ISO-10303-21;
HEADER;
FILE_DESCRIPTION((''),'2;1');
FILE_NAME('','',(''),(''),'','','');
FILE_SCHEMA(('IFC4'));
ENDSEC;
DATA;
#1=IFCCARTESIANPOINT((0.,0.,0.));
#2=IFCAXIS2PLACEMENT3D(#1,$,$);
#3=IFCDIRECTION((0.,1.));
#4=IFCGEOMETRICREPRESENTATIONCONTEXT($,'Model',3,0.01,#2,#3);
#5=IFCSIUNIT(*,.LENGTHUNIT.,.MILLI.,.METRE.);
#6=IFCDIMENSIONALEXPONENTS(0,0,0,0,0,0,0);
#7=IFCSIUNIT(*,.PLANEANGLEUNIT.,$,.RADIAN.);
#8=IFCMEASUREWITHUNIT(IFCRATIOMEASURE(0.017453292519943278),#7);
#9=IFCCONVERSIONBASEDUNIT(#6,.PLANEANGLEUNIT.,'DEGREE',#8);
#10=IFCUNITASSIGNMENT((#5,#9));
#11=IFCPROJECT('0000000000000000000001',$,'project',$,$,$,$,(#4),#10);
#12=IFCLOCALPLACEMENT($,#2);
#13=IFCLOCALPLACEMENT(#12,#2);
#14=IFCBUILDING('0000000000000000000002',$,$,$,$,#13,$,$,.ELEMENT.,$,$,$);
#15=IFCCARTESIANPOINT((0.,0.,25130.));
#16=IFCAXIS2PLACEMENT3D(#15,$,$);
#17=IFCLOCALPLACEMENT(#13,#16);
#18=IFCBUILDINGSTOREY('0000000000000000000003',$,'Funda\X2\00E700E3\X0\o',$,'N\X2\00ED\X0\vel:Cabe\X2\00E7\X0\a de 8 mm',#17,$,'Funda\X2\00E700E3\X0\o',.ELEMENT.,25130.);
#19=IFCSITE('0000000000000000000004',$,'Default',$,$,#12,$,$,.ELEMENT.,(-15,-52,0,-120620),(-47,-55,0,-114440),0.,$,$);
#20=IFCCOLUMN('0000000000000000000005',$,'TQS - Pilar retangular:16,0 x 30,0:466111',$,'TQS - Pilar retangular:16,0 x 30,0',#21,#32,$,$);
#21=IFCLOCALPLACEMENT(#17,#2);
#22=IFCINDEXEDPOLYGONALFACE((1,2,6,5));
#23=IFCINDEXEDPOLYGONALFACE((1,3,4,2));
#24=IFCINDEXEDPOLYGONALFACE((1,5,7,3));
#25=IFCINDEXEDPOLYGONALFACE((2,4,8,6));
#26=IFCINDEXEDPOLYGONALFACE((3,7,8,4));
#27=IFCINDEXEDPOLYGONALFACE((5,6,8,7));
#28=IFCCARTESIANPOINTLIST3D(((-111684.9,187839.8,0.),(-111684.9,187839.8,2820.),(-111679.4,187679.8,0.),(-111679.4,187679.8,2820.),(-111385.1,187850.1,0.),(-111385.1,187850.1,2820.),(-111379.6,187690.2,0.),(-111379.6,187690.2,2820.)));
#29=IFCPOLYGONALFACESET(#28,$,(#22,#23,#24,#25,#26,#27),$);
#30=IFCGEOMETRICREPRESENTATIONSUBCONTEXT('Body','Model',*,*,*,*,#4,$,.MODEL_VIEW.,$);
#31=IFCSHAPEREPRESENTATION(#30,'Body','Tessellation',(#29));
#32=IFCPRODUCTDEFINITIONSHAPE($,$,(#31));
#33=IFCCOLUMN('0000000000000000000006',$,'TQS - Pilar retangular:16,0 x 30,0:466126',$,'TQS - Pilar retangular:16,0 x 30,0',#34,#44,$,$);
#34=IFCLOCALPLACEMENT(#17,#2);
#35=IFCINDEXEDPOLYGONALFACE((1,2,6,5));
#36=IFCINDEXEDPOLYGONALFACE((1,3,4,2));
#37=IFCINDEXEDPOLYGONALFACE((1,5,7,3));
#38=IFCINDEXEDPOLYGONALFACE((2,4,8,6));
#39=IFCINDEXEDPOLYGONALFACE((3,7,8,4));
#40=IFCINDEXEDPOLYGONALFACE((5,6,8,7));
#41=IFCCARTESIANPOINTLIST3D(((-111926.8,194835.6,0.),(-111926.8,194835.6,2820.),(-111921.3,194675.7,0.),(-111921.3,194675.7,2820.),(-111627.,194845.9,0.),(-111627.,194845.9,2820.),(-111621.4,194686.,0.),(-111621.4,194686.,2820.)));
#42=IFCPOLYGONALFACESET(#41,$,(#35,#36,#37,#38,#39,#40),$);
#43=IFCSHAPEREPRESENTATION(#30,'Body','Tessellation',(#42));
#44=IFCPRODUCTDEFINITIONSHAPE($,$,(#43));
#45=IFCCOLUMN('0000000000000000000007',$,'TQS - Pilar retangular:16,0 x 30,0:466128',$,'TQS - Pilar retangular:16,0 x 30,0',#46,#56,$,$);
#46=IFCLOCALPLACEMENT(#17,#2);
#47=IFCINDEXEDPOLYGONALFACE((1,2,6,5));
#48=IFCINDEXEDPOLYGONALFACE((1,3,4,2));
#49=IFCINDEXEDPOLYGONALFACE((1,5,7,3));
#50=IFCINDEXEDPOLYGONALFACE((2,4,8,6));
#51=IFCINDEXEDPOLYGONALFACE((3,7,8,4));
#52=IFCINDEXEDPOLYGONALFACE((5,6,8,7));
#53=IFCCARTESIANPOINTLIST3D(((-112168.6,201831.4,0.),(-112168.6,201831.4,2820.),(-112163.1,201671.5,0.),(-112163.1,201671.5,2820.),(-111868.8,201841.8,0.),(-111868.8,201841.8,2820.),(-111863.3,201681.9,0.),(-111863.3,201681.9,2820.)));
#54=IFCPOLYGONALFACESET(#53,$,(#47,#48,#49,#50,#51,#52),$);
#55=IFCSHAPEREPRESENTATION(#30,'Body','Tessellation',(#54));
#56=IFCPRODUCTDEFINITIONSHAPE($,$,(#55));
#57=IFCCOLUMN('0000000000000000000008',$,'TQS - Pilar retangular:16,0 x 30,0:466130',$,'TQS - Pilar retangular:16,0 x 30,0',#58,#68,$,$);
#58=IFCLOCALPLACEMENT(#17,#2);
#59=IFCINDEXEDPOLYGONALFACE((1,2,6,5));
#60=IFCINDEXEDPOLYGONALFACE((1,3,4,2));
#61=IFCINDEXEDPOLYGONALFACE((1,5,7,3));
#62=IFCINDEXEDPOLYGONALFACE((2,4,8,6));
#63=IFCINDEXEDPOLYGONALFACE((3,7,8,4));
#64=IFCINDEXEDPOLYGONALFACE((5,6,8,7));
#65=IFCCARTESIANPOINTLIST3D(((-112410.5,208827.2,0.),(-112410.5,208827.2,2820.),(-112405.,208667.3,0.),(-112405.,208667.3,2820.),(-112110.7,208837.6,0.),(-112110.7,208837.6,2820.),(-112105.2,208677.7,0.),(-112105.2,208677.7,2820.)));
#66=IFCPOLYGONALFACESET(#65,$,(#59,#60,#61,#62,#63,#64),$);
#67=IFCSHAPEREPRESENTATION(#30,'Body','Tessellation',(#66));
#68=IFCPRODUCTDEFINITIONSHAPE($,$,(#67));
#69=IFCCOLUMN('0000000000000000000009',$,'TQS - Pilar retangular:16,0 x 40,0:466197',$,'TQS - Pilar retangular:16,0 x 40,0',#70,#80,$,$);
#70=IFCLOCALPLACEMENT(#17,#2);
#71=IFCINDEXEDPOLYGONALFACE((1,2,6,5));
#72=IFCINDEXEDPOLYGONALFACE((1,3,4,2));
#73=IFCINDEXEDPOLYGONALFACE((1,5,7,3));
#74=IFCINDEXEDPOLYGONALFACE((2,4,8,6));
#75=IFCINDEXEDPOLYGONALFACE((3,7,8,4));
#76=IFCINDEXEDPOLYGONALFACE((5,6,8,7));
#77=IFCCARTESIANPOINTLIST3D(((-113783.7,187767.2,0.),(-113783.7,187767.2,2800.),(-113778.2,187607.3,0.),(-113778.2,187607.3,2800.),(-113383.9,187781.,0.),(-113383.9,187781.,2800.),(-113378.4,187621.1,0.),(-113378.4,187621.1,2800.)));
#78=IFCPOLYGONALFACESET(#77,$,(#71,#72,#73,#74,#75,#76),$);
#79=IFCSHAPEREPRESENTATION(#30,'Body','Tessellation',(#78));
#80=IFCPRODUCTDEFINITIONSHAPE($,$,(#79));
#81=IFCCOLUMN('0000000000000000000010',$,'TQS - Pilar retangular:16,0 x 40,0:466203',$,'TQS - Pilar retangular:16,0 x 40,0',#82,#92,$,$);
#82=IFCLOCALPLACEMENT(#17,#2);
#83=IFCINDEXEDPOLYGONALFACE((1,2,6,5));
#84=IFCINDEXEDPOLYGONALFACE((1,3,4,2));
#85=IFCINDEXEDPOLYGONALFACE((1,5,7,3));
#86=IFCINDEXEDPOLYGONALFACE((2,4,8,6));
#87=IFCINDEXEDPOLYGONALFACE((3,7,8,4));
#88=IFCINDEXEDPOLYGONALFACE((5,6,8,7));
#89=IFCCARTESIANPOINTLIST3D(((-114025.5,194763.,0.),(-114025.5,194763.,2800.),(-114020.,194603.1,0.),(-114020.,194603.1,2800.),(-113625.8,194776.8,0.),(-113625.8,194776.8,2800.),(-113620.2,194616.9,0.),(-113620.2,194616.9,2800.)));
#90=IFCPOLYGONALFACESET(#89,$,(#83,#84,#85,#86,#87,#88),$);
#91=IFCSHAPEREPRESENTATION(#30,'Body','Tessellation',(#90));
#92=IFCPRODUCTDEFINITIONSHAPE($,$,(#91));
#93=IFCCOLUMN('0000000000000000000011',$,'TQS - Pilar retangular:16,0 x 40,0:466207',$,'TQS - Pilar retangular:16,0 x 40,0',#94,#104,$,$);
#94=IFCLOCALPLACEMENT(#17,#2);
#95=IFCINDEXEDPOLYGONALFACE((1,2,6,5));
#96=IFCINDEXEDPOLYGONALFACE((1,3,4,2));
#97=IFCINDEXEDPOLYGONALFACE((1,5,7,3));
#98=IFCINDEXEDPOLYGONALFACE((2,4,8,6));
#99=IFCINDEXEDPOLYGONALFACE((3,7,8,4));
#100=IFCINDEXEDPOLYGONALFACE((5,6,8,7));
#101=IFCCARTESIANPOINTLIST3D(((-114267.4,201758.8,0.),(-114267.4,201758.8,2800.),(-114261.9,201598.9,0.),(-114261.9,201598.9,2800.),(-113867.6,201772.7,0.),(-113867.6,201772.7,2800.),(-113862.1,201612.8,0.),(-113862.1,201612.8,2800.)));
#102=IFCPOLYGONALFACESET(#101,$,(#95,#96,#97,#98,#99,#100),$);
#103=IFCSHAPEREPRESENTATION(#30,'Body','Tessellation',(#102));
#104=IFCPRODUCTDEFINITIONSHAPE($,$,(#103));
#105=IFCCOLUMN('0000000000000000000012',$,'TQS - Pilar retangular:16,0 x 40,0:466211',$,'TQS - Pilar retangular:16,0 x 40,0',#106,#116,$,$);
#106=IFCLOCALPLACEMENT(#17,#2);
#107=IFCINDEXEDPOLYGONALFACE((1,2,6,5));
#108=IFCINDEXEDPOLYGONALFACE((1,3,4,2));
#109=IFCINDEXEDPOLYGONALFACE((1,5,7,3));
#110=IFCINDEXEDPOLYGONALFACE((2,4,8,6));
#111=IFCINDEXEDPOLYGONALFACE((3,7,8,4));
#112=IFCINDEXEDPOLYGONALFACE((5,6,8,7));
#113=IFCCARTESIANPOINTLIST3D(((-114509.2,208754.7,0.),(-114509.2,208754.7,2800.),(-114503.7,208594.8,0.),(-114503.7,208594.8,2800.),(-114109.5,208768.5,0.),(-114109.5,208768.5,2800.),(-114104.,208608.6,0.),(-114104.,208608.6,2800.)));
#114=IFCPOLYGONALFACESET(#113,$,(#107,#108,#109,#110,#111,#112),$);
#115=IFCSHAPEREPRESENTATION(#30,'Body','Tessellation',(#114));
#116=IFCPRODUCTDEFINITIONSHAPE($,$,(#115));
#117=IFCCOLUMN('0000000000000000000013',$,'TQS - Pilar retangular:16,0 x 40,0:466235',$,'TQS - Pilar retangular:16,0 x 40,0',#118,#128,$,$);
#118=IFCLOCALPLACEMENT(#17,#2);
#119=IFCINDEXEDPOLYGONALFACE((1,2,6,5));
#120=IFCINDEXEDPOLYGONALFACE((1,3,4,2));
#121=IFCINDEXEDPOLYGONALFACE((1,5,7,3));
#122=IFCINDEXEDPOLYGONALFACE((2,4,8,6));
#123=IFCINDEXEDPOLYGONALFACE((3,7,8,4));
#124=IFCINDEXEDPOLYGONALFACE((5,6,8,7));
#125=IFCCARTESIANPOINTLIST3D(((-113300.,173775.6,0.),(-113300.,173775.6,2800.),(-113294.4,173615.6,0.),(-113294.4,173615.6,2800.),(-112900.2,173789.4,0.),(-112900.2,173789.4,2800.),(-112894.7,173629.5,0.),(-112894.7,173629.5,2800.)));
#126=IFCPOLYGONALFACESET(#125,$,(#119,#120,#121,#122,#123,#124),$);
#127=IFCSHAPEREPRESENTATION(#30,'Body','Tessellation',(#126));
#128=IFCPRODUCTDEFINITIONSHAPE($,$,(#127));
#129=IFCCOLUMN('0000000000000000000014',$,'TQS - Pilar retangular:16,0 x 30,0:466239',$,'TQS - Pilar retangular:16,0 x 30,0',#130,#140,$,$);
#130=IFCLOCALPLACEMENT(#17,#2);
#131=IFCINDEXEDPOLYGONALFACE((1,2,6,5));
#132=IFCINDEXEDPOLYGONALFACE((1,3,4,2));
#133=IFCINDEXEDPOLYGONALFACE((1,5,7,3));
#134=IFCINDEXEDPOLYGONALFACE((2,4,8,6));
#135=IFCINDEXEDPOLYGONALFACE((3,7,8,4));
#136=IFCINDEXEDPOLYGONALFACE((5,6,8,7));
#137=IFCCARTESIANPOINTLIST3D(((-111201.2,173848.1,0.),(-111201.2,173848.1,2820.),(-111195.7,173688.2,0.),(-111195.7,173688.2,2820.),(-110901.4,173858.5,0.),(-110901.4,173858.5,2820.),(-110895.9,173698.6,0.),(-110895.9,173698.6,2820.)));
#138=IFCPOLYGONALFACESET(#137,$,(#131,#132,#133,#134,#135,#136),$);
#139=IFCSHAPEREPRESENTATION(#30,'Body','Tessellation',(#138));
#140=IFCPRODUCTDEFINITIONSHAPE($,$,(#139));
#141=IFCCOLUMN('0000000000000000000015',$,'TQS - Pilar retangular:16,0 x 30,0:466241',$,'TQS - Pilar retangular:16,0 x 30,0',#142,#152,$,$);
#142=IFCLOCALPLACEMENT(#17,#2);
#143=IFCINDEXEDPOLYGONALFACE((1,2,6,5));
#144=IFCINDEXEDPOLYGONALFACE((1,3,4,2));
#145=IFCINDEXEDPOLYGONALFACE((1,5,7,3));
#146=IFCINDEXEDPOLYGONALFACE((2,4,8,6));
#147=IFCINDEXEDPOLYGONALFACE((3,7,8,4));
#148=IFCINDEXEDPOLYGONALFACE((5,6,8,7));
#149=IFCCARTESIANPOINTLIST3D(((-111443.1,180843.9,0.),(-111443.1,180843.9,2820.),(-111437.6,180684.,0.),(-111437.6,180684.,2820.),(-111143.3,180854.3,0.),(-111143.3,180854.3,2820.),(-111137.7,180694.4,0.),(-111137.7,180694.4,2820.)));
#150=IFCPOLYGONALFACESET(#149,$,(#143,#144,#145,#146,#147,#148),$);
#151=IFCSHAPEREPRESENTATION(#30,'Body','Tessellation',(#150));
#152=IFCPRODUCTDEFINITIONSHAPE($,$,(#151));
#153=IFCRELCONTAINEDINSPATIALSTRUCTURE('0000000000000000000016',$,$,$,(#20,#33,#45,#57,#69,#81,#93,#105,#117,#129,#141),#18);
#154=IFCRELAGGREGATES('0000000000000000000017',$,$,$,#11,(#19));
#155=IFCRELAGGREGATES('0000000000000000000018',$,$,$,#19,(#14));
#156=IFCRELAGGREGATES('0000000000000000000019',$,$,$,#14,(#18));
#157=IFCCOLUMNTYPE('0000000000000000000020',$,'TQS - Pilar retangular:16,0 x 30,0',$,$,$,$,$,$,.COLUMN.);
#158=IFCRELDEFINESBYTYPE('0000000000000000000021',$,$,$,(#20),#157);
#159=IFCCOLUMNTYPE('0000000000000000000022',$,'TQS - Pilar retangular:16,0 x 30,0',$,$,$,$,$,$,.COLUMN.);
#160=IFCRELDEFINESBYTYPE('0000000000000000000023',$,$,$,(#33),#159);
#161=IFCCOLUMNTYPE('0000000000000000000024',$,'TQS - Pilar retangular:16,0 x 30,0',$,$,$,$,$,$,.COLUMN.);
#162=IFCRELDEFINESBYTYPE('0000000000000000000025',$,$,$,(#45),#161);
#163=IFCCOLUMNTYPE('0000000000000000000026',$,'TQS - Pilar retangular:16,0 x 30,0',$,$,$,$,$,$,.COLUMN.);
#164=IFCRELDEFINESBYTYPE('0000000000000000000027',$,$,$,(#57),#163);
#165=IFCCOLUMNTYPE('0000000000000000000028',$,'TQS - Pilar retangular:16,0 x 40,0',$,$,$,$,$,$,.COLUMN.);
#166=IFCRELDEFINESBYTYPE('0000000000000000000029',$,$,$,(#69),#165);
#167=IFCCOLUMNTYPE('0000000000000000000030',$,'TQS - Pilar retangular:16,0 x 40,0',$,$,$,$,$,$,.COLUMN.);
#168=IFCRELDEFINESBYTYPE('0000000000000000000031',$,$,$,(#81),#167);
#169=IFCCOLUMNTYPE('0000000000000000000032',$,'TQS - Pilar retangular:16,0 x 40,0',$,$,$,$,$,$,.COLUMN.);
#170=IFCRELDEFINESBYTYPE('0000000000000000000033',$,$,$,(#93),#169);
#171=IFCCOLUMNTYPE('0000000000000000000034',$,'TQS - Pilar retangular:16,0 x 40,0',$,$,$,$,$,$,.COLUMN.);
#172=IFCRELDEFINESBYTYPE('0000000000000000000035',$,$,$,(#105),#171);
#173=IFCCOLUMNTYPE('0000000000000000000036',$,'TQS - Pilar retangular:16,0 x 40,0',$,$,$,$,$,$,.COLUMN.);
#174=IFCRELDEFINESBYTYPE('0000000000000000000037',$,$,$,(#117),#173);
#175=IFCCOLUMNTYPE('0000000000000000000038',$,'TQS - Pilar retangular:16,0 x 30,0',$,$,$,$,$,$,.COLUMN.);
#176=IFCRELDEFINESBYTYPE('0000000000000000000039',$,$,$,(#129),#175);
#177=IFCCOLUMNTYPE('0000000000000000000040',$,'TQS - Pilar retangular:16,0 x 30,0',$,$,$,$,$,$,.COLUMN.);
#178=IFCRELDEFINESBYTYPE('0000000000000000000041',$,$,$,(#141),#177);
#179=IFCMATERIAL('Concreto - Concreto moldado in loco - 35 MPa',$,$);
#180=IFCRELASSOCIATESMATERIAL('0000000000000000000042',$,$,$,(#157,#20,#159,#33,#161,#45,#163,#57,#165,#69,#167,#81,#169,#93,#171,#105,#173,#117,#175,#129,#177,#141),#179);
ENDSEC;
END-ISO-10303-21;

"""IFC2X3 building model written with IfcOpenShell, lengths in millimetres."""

from ifc_helpers import new_model, entity, si_unit, converted_unit, direction, frame, frame_2d, origin, origin_2d_with_axis, place, context, subcontext, project, spatial, rectangle, extrude, source, transform, mapped, material, type_object, type_shapes, element, save


model = new_model("IFC2X3")

# Units and contexts
model_context = context("Model", 3, precision=0.01, world=origin(), true_north=direction((0.0, 1.0)))
body_context = subcontext(model_context, "Body", "Model", "MODEL_VIEW")
ifc_project = project(units=[si_unit("LENGTHUNIT", "METRE", prefix="MILLI"), converted_unit("PLANEANGLEUNIT", "DEGREE", entity("IfcRatioMeasure", 0.017453292519943278), si_unit("PLANEANGLEUNIT", "RADIAN"), dimensions=[0, 0, 0, 0, 0, 0, 0])], contexts=[model_context])

# Site, building, storey
site_placement = place(None, origin())
site = spatial("IfcSite", under=ifc_project, at=site_placement, Name="Default", CompositionType="ELEMENT", RefLatitude=(-15, -52, 0, -120620), RefLongitude=(-47, -55, 0, -114440), RefElevation=0.0)
building_placement = place(site_placement, origin())
building = spatial("IfcBuilding", under=site, at=building_placement, CompositionType="ELEMENT")
storey_placement = place(building_placement, frame((0.0, 0.0, 25130.0)))
storey = spatial("IfcBuildingStorey", under=building, at=storey_placement, Name="Fundação", ObjectType="Nível:Cabeça de 8 mm", LongName="Fundação", CompositionType="ELEMENT", Elevation=25130.0)

# Columns
ifc_material_1 = material(Name="Concreto - Concreto moldado in loco - 35 MPa")
column_type_1 = type_object("IfcColumnType", Name="TQS - Pilar retangular:16,0 x 30,0", PredefinedType="COLUMN", material=ifc_material_1)
shared_shape_1 = source(origin(), body_context, "Body", "SweptSolid", [
    extrude(rectangle(XDim=300.0, YDim=160.0, at=origin_2d_with_axis()), frame((-111532.3, 187765.0, 25130.0), z_axis=(0.0, 0.0, 1.0), x_axis=(-0.999403, -0.034551, 0.0)), (0.0, 0.0, 1.0), 2820.0),
])
type_shapes(column_type_1, [shared_shape_1])
column_1_placement = place(storey_placement, frame((0.0, 0.0, -25130.0)))
element("IfcColumn", 1, at=column_1_placement, inside=storey, type_object=column_type_1, material=ifc_material_1, Name="TQS - Pilar retangular:16,0 x 30,0:466111", ObjectType="TQS - Pilar retangular:16,0 x 30,0", context=body_context, shape_type="MappedRepresentation", body=[
    mapped(shared_shape_1, transform((0.0, 0.0, 0.0), scale=1.0)),
])
column_type_2 = type_object("IfcColumnType", Name="TQS - Pilar retangular:16,0 x 30,0", PredefinedType="COLUMN", material=ifc_material_1)
shared_shape_2 = source(origin(), body_context, "Body", "SweptSolid", [
    extrude(rectangle(XDim=300.0, YDim=160.0, at=origin_2d_with_axis()), frame((-111774.1, 194760.8, 25130.0), z_axis=(0.0, 0.0, 1.0), x_axis=(-0.999403, -0.034551, 0.0)), (0.0, 0.0, 1.0), 2820.0),
])
type_shapes(column_type_2, [shared_shape_2])
column_2_placement = place(storey_placement, frame((0.0, 0.0, -25130.0)))
element("IfcColumn", 2, at=column_2_placement, inside=storey, type_object=column_type_2, material=ifc_material_1, Name="TQS - Pilar retangular:16,0 x 30,0:466126", ObjectType="TQS - Pilar retangular:16,0 x 30,0", context=body_context, shape_type="MappedRepresentation", body=[
    mapped(shared_shape_2, transform((0.0, 0.0, 0.0), scale=1.0)),
])
column_type_3 = type_object("IfcColumnType", Name="TQS - Pilar retangular:16,0 x 30,0", PredefinedType="COLUMN", material=ifc_material_1)
shared_shape_3 = source(origin(), body_context, "Body", "SweptSolid", [
    extrude(rectangle(XDim=300.0, YDim=160.0, at=origin_2d_with_axis()), frame((-112016.0, 201756.6, 25130.0), z_axis=(0.0, 0.0, 1.0), x_axis=(-0.999403, -0.034551, 0.0)), (0.0, 0.0, 1.0), 2820.0),
])
type_shapes(column_type_3, [shared_shape_3])
column_3_placement = place(storey_placement, frame((0.0, 0.0, -25130.0)))
element("IfcColumn", 3, at=column_3_placement, inside=storey, type_object=column_type_3, material=ifc_material_1, Name="TQS - Pilar retangular:16,0 x 30,0:466128", ObjectType="TQS - Pilar retangular:16,0 x 30,0", context=body_context, shape_type="MappedRepresentation", body=[
    mapped(shared_shape_3, transform((0.0, 0.0, 0.0), scale=1.0)),
])
column_type_4 = type_object("IfcColumnType", Name="TQS - Pilar retangular:16,0 x 30,0", PredefinedType="COLUMN", material=ifc_material_1)
shared_shape_4 = source(origin(), body_context, "Body", "SweptSolid", [
    extrude(rectangle(XDim=300.0, YDim=160.0, at=origin_2d_with_axis()), frame((-112257.8, 208752.4, 25130.0), z_axis=(0.0, 0.0, 1.0), x_axis=(-0.999403, -0.034551, 0.0)), (0.0, 0.0, 1.0), 2820.0),
])
type_shapes(column_type_4, [shared_shape_4])
column_4_placement = place(storey_placement, frame((0.0, 0.0, -25130.0)))
element("IfcColumn", 4, at=column_4_placement, inside=storey, type_object=column_type_4, material=ifc_material_1, Name="TQS - Pilar retangular:16,0 x 30,0:466130", ObjectType="TQS - Pilar retangular:16,0 x 30,0", context=body_context, shape_type="MappedRepresentation", body=[
    mapped(shared_shape_4, transform((0.0, 0.0, 0.0), scale=1.0)),
])
column_type_5 = type_object("IfcColumnType", Name="TQS - Pilar retangular:16,0 x 40,0", PredefinedType="COLUMN", material=ifc_material_1)
shared_shape_5 = source(origin(), body_context, "Body", "SweptSolid", [
    extrude(rectangle(XDim=400.0, YDim=160.0, at=origin_2d_with_axis()), frame((-113581.0, 187694.2, 25130.0), z_axis=(0.0, 0.0, 1.0), x_axis=(-0.999403, -0.034551, 0.0)), (0.0, 0.0, 1.0), 2800.0),
])
type_shapes(column_type_5, [shared_shape_5])
column_5_placement = place(storey_placement, frame((0.0, 0.0, -25130.0)))
element("IfcColumn", 5, at=column_5_placement, inside=storey, type_object=column_type_5, material=ifc_material_1, Name="TQS - Pilar retangular:16,0 x 40,0:466197", ObjectType="TQS - Pilar retangular:16,0 x 40,0", context=body_context, shape_type="MappedRepresentation", body=[
    mapped(shared_shape_5, transform((0.0, 0.0, 0.0), scale=1.0)),
])
column_type_6 = type_object("IfcColumnType", Name="TQS - Pilar retangular:16,0 x 40,0", PredefinedType="COLUMN", material=ifc_material_1)
shared_shape_6 = source(origin(), body_context, "Body", "SweptSolid", [
    extrude(rectangle(XDim=400.0, YDim=160.0, at=origin_2d_with_axis()), frame((-113822.9, 194690.0, 25130.0), z_axis=(0.0, 0.0, 1.0), x_axis=(-0.999403, -0.034551, 0.0)), (0.0, 0.0, 1.0), 2800.0),
])
type_shapes(column_type_6, [shared_shape_6])
column_6_placement = place(storey_placement, frame((0.0, 0.0, -25130.0)))
element("IfcColumn", 6, at=column_6_placement, inside=storey, type_object=column_type_6, material=ifc_material_1, Name="TQS - Pilar retangular:16,0 x 40,0:466203", ObjectType="TQS - Pilar retangular:16,0 x 40,0", context=body_context, shape_type="MappedRepresentation", body=[
    mapped(shared_shape_6, transform((0.0, 0.0, 0.0), scale=1.0)),
])
column_type_7 = type_object("IfcColumnType", Name="TQS - Pilar retangular:16,0 x 40,0", PredefinedType="COLUMN", material=ifc_material_1)
shared_shape_7 = source(origin(), body_context, "Body", "SweptSolid", [
    extrude(rectangle(XDim=400.0, YDim=160.0, at=origin_2d_with_axis()), frame((-114064.7, 201685.8, 25130.0), z_axis=(0.0, 0.0, 1.0), x_axis=(-0.999403, -0.034551, 0.0)), (0.0, 0.0, 1.0), 2800.0),
])
type_shapes(column_type_7, [shared_shape_7])
column_7_placement = place(storey_placement, frame((0.0, 0.0, -25130.0)))
element("IfcColumn", 7, at=column_7_placement, inside=storey, type_object=column_type_7, material=ifc_material_1, Name="TQS - Pilar retangular:16,0 x 40,0:466207", ObjectType="TQS - Pilar retangular:16,0 x 40,0", context=body_context, shape_type="MappedRepresentation", body=[
    mapped(shared_shape_7, transform((0.0, 0.0, 0.0), scale=1.0)),
])
column_type_8 = type_object("IfcColumnType", Name="TQS - Pilar retangular:16,0 x 40,0", PredefinedType="COLUMN", material=ifc_material_1)
shared_shape_8 = source(origin(), body_context, "Body", "SweptSolid", [
    extrude(rectangle(XDim=400.0, YDim=160.0, at=frame_2d((0.0, 0.0), x_axis=(1.0, 0.0))), frame((-114306.6, 208681.6, 25130.0), z_axis=(0.0, 0.0, 1.0), x_axis=(-0.999403, -0.034551, 0.0)), (0.0, 0.0, 1.0), 2800.0),
])
type_shapes(column_type_8, [shared_shape_8])
column_8_placement = place(storey_placement, frame((0.0, 0.0, -25130.0)))
element("IfcColumn", 8, at=column_8_placement, inside=storey, type_object=column_type_8, material=ifc_material_1, Name="TQS - Pilar retangular:16,0 x 40,0:466211", ObjectType="TQS - Pilar retangular:16,0 x 40,0", context=body_context, shape_type="MappedRepresentation", body=[
    mapped(shared_shape_8, transform((0.0, 0.0, 0.0), scale=1.0)),
])
column_type_9 = type_object("IfcColumnType", Name="TQS - Pilar retangular:16,0 x 40,0", PredefinedType="COLUMN", material=ifc_material_1)
shared_shape_9 = source(origin(), body_context, "Body", "SweptSolid", [
    extrude(rectangle(XDim=400.0, YDim=160.0, at=origin_2d_with_axis()), frame((-113097.3, 173702.5, 25130.0), z_axis=(0.0, 0.0, 1.0), x_axis=(-0.999403, -0.034551, 0.0)), (0.0, 0.0, 1.0), 2800.0),
])
type_shapes(column_type_9, [shared_shape_9])
column_9_placement = place(storey_placement, frame((0.0, 0.0, -25130.0)))
element("IfcColumn", 9, at=column_9_placement, inside=storey, type_object=column_type_9, material=ifc_material_1, Name="TQS - Pilar retangular:16,0 x 40,0:466235", ObjectType="TQS - Pilar retangular:16,0 x 40,0", context=body_context, shape_type="MappedRepresentation", body=[
    mapped(shared_shape_9, transform((0.0, 0.0, 0.0), scale=1.0)),
])
column_type_10 = type_object("IfcColumnType", Name="TQS - Pilar retangular:16,0 x 30,0", PredefinedType="COLUMN", material=ifc_material_1)
shared_shape_10 = source(origin(), body_context, "Body", "SweptSolid", [
    extrude(rectangle(XDim=300.0, YDim=160.0, at=origin_2d_with_axis()), frame((-111048.6, 173773.3, 25130.0), z_axis=(0.0, 0.0, 1.0), x_axis=(-0.999403, -0.034551, 0.0)), (0.0, 0.0, 1.0), 2820.0),
])
type_shapes(column_type_10, [shared_shape_10])
column_10_placement = place(storey_placement, frame((0.0, 0.0, -25130.0)))
element("IfcColumn", 10, at=column_10_placement, inside=storey, type_object=column_type_10, material=ifc_material_1, Name="TQS - Pilar retangular:16,0 x 30,0:466239", ObjectType="TQS - Pilar retangular:16,0 x 30,0", context=body_context, shape_type="MappedRepresentation", body=[
    mapped(shared_shape_10, transform((0.0, 0.0, 0.0), scale=1.0)),
])
column_type_11 = type_object("IfcColumnType", Name="TQS - Pilar retangular:16,0 x 30,0", PredefinedType="COLUMN", material=ifc_material_1)
shared_shape_11 = source(origin(), body_context, "Body", "SweptSolid", [
    extrude(rectangle(XDim=300.0, YDim=160.0, at=origin_2d_with_axis()), frame((-111290.4, 180769.2, 25130.0), z_axis=(0.0, 0.0, 1.0), x_axis=(-0.999403, -0.034551, 0.0)), (0.0, 0.0, 1.0), 2820.0),
])
type_shapes(column_type_11, [shared_shape_11])
column_11_placement = place(storey_placement, frame((0.0, 0.0, -25130.0)))
element("IfcColumn", 11, at=column_11_placement, inside=storey, type_object=column_type_11, material=ifc_material_1, Name="TQS - Pilar retangular:16,0 x 30,0:466241", ObjectType="TQS - Pilar retangular:16,0 x 30,0", context=body_context, shape_type="MappedRepresentation", body=[
    mapped(shared_shape_11, transform((0.0, 0.0, 0.0), scale=1.0)),
])

save(model, "model.ifc")
